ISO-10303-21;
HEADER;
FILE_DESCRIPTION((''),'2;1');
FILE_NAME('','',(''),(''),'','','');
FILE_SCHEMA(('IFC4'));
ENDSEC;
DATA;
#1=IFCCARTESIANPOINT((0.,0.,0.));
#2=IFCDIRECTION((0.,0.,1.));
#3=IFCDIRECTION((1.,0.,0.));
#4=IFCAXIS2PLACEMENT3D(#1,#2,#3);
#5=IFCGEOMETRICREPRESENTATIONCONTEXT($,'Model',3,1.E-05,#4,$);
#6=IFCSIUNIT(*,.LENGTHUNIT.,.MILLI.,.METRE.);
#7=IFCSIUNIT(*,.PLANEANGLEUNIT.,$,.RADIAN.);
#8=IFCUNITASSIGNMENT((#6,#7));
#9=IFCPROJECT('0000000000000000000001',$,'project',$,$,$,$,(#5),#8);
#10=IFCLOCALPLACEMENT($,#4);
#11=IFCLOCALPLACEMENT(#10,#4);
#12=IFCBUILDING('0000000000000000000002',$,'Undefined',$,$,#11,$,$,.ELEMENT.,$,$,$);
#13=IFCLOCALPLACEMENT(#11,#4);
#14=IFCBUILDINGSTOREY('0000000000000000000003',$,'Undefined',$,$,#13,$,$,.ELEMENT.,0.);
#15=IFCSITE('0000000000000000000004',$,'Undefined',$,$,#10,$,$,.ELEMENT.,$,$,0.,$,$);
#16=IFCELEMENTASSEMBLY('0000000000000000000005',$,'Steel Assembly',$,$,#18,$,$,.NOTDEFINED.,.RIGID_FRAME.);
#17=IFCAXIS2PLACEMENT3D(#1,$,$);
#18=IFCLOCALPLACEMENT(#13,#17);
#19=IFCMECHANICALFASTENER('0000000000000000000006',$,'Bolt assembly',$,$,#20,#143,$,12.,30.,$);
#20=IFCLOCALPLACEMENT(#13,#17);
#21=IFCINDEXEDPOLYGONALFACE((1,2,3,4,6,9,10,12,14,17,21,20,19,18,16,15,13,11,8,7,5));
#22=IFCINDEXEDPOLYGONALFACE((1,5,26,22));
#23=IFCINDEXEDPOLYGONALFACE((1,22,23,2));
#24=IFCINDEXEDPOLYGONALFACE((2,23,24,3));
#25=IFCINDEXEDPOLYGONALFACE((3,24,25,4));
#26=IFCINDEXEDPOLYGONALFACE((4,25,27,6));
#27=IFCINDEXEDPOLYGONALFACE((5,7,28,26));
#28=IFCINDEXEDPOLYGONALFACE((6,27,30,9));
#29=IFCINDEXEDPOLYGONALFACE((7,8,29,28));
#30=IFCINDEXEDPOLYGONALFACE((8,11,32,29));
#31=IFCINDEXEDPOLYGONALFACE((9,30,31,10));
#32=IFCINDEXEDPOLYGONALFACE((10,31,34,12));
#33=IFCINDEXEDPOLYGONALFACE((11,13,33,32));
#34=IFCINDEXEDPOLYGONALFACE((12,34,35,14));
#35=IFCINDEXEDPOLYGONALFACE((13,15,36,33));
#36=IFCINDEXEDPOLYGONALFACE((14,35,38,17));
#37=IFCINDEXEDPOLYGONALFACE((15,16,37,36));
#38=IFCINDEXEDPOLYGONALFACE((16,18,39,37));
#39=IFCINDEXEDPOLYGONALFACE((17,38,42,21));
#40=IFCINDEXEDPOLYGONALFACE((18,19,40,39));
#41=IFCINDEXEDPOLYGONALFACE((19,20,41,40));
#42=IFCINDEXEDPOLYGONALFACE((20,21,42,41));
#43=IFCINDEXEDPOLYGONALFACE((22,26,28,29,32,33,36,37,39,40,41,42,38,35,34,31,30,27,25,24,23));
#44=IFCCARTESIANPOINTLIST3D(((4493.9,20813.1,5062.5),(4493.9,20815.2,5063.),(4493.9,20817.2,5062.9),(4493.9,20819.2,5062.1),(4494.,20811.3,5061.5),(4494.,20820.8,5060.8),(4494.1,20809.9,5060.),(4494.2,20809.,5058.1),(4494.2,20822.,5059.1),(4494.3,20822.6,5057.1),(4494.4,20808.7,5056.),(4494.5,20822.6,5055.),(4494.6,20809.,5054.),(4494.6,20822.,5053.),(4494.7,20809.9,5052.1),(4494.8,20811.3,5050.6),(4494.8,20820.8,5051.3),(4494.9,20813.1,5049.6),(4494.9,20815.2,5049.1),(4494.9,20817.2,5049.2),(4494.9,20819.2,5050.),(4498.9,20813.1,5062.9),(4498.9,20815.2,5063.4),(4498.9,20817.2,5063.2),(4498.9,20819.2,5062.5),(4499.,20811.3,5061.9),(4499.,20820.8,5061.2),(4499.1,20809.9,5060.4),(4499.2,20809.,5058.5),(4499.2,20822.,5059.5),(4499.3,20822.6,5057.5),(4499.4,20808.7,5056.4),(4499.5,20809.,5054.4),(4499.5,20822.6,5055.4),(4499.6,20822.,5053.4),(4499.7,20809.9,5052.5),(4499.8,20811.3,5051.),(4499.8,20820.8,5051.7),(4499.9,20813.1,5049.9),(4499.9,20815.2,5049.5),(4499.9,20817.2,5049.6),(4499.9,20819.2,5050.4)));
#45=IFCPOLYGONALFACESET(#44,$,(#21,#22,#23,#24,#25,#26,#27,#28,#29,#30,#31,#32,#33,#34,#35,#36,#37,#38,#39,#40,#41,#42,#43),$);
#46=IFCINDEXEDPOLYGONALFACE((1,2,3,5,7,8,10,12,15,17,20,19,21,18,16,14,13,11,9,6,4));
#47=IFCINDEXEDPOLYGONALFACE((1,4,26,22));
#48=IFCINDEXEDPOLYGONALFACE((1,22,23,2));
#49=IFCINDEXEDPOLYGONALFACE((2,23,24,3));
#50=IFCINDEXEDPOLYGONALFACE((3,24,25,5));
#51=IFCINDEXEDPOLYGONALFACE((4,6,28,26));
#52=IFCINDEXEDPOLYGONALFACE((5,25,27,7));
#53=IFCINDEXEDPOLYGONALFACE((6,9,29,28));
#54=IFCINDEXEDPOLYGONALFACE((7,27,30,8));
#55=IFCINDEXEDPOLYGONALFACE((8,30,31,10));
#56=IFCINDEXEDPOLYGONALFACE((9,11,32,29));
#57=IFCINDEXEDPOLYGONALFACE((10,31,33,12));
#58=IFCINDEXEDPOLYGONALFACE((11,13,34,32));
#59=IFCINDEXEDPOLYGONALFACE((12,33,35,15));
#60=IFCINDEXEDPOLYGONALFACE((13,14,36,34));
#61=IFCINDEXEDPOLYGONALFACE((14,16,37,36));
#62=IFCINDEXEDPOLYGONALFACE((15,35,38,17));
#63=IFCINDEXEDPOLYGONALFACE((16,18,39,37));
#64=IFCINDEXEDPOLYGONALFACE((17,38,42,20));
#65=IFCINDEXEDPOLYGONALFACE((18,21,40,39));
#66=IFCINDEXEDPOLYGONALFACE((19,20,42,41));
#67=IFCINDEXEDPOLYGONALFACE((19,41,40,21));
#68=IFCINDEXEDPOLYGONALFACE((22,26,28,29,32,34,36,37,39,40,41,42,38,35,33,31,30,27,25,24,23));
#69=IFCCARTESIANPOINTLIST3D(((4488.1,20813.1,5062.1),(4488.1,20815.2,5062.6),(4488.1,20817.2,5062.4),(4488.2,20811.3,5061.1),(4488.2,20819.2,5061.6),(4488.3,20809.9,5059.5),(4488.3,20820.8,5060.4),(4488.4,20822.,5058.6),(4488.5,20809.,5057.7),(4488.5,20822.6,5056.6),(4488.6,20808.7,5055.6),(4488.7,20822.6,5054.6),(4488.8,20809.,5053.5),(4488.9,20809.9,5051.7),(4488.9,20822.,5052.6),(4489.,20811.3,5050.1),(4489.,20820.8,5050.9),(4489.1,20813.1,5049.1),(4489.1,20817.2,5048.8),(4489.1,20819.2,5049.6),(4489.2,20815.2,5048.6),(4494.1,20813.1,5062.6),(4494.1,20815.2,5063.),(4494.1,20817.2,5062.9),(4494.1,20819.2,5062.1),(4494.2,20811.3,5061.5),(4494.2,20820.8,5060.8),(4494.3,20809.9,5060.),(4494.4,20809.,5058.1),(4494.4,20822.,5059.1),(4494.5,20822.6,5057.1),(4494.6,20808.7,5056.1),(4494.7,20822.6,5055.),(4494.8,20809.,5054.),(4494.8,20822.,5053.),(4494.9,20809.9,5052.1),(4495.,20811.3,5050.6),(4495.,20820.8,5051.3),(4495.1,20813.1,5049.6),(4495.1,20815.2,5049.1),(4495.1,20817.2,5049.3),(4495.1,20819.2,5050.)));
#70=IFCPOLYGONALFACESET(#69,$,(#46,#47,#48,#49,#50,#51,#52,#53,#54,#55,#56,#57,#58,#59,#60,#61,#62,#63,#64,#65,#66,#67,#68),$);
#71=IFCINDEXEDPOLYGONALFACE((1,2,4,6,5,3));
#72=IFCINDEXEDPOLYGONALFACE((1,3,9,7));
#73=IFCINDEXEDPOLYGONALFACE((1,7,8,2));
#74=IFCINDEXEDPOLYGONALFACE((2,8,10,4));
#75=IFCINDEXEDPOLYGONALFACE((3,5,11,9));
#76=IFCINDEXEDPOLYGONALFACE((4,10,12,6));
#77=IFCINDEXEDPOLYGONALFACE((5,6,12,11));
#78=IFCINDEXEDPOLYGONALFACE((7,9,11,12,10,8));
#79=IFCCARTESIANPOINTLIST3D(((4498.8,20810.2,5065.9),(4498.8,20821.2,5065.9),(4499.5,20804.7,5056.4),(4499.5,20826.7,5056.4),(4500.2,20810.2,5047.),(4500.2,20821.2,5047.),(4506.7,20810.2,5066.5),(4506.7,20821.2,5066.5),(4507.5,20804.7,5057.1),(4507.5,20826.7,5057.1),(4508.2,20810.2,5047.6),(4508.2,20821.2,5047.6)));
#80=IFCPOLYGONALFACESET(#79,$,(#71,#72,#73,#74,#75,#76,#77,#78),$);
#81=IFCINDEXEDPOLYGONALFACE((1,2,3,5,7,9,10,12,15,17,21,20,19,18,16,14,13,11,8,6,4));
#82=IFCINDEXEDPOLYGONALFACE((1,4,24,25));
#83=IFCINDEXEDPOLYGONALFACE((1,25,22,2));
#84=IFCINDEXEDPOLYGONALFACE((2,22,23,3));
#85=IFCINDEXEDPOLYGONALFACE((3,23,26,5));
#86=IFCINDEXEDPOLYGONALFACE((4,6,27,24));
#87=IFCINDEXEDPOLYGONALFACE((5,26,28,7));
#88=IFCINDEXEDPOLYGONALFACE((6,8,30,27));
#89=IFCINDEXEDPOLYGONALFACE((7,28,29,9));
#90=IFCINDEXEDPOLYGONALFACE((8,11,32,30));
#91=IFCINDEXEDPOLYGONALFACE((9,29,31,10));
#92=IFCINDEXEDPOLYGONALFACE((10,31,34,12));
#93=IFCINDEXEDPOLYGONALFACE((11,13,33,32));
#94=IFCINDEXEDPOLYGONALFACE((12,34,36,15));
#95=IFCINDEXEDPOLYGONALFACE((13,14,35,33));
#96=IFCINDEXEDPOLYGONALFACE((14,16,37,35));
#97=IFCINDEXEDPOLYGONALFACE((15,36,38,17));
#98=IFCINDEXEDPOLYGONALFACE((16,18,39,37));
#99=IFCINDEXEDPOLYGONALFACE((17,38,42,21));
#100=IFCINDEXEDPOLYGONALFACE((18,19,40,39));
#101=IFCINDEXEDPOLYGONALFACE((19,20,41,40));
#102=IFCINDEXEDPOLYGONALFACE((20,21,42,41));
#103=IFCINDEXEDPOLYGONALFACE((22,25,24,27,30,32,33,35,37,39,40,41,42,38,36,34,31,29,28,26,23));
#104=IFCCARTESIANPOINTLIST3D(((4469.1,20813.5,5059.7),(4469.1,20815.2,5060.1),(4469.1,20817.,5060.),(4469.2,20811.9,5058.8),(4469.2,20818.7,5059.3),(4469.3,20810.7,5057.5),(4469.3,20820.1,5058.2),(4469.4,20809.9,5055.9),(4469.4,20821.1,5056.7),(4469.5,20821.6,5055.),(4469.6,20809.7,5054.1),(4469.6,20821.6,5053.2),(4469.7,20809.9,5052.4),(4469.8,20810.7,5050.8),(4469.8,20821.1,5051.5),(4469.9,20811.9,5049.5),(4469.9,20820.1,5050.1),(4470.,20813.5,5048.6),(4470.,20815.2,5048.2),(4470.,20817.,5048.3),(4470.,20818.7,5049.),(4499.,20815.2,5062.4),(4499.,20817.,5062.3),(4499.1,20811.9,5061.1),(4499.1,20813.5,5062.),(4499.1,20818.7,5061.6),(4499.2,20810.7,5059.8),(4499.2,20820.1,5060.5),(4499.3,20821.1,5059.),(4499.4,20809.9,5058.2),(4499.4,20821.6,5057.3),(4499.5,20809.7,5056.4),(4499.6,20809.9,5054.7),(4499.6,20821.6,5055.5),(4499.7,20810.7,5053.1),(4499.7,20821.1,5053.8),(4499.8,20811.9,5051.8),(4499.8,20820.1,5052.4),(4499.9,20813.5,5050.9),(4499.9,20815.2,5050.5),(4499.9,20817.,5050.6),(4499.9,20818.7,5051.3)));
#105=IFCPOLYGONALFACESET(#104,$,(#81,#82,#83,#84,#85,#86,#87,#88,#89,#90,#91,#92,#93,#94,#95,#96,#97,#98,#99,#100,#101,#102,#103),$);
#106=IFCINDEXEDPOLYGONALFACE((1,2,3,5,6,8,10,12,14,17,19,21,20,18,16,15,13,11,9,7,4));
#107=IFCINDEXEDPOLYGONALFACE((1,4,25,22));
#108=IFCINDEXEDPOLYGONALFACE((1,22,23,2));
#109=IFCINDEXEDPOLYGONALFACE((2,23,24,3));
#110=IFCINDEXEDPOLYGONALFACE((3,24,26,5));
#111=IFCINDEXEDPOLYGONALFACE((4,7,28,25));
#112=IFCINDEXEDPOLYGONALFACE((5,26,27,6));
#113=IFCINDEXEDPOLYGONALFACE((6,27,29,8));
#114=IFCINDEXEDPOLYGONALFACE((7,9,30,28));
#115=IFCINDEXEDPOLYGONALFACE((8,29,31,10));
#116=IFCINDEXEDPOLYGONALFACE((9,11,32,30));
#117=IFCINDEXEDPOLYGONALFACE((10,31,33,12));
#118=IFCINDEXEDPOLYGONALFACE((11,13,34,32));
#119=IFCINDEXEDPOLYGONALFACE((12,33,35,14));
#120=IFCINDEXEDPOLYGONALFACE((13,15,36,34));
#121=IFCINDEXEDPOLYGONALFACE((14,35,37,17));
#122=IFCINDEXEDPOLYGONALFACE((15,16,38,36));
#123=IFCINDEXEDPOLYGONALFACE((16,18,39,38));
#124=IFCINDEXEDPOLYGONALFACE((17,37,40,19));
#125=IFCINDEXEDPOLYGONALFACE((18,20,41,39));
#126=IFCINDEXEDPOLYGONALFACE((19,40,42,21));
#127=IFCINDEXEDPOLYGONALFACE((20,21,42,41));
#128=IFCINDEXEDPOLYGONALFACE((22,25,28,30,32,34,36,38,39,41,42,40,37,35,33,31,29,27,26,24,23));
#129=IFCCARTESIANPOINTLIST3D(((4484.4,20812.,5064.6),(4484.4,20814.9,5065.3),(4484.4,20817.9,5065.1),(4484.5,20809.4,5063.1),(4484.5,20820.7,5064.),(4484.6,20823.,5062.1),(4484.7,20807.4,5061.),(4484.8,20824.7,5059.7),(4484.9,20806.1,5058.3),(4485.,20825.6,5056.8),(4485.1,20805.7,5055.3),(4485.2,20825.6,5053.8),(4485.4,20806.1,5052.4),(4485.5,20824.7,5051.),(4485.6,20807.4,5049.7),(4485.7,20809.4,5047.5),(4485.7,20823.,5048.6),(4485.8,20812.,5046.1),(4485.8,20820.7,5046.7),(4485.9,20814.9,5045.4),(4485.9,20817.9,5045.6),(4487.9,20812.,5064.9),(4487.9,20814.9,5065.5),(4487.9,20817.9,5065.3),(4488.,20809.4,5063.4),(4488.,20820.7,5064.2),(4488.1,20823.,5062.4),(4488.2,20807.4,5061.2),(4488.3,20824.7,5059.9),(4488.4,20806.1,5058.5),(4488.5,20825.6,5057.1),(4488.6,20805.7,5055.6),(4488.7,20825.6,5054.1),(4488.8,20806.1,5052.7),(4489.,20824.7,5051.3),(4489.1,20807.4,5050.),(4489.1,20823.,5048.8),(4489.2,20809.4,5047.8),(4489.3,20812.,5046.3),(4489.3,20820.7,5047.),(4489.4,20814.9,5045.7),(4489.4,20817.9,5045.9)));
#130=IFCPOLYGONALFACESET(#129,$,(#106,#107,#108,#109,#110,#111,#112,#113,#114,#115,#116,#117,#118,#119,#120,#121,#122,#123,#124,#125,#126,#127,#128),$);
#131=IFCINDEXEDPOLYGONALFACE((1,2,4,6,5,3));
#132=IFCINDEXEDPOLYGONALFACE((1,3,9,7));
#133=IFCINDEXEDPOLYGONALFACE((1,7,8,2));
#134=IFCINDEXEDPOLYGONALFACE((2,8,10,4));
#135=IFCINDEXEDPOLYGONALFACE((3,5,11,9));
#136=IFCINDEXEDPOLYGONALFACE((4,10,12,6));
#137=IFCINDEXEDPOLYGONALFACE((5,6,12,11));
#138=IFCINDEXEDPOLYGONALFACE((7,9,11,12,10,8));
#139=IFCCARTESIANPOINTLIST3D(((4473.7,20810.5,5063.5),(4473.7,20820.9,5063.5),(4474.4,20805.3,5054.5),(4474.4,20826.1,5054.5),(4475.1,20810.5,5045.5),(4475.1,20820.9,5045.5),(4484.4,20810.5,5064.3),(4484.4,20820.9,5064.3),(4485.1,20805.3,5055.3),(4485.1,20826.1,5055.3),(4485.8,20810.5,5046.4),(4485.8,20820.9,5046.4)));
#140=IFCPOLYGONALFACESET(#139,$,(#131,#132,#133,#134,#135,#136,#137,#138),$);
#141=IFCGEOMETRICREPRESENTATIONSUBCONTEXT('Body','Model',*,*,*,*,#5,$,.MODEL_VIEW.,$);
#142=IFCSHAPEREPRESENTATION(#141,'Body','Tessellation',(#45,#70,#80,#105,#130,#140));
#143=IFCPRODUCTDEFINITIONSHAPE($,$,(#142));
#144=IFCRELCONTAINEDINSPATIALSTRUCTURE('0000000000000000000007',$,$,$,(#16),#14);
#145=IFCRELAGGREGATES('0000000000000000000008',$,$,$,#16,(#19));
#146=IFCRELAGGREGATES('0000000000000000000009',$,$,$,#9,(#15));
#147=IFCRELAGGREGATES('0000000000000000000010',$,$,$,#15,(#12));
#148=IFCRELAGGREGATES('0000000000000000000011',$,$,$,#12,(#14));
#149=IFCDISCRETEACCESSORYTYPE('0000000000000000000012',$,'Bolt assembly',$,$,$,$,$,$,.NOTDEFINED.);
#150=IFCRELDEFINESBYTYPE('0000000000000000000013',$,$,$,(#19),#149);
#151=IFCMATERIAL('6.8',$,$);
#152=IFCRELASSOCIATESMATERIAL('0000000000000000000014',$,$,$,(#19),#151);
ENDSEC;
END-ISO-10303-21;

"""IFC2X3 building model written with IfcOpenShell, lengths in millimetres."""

from ifc_helpers import new_model, si_unit, frame, origin_with_axes, origin_2d_with_axis, place, context, subcontext, project, spatial, polyline, circle, outline, extrude, source, transform, mapped, material, type_object, element, aggregate, save


model = new_model("IFC2X3")

# Units and contexts
model_context = context("Model", 3, precision=1e-05, world=origin_with_axes())
body_context = subcontext(model_context, "Body", "Model", "MODEL_VIEW")
ifc_project = project(units=[si_unit("LENGTHUNIT", "METRE", prefix="MILLI"), si_unit("PLANEANGLEUNIT", "RADIAN")], contexts=[model_context])

# Site, building, storey
site_placement = place(None, origin_with_axes())
site = spatial("IfcSite", under=ifc_project, at=site_placement, Name="Undefined", CompositionType="ELEMENT", RefElevation=0.0)
building_placement = place(site_placement, origin_with_axes())
building = spatial("IfcBuilding", under=site, at=building_placement, Name="Undefined", CompositionType="ELEMENT")
storey_placement = place(building_placement, origin_with_axes())
storey = spatial("IfcBuildingStorey", under=building, at=storey_placement, Name="Undefined", CompositionType="ELEMENT", Elevation=0.0)

# Shared definitions
ifc_material_1 = material(Name="6.8")
discrete_accessory_type_1 = type_object("IfcDiscreteAccessoryType", Name="Bolt assembly")

# Element assembly, mechanical fastener
assembly_1_placement = place(storey_placement, origin_with_axes())
assembly_1 = element("IfcElementAssembly", 1, at=assembly_1_placement, inside=storey, Name="Steel Assembly", AssemblyPlace="NOTDEFINED", PredefinedType="RIGID_FRAME")
shared_shape_1 = source(origin_with_axes(), body_context, "Body", "SweptSolid", [
    extrude(circle(Radius=7.0, at=origin_2d_with_axis()), frame((0.0, -4.9, 0.0), z_axis=(0.0, 1.0, 0.0), x_axis=(1.0, 0.0, 0.0)), (0.0, 0.0, 1.0), 5.0),
    extrude(circle(Radius=7.0, at=origin_2d_with_axis()), frame((0.0, -0.1, 0.0), z_axis=(0.0, 1.0, 0.0), x_axis=(1.0, 0.0, 0.0)), (0.0, 0.0, 1.0), 6.0),
    extrude(outline(polyline([(11.0, 0.0), (5.5, 9.5), (-5.5, 9.5), (-11.0, 0.0), (-5.5, -9.5), (5.5, -9.5), (11.0, 0.0)])), frame((0.0, -13.0, 0.0), z_axis=(0.0, 1.0, 0.0), x_axis=(1.0, 0.0, 0.0)), (0.0, 0.0, 1.0), 8.0),
    extrude(circle(Radius=6.0, at=origin_2d_with_axis()), frame((0.0, -5.0, 0.0), z_axis=(0.0, 1.0, 0.0), x_axis=(1.0, 0.0, 0.0)), (0.0, 0.0, 1.0), 30.0),
    extrude(circle(Radius=10.0, at=origin_2d_with_axis()), frame((0.0, 5.9, 0.0), z_axis=(0.0, 1.0, 0.0), x_axis=(1.0, 0.0, 0.0)), (0.0, 0.0, 1.0), 3.5),
    extrude(outline(polyline([(10.4, 0.0), (5.2, 9.0), (-5.2, 9.0), (-10.4, 0.0), (-5.2, -9.0), (5.2, -9.0), (10.4, 0.0)])), frame((0.0, 9.4, 0.0), z_axis=(0.0, 1.0, 0.0), x_axis=(1.0, 0.0, 0.0)), (0.0, 0.0, 1.0), 10.8),
])
mechanical_fastener_1_placement = place(assembly_1_placement, frame((4494.5, 20815.7, 5056.1), z_axis=(0.076696, 0.0, -0.997054), x_axis=(0.0, -1.0, 0.0)))
mechanical_fastener_1 = element("IfcMechanicalFastener", 2, at=mechanical_fastener_1_placement, type_object=discrete_accessory_type_1, material=ifc_material_1, Name="Bolt assembly", NominalDiameter=12.0, NominalLength=30.0, context=body_context, shape_type="MappedRepresentation", body=[
    mapped(shared_shape_1, transform((0.0, 0.0, 0.0))),
])
aggregate(assembly_1, [mechanical_fastener_1])

save(model, "model.ifc")
